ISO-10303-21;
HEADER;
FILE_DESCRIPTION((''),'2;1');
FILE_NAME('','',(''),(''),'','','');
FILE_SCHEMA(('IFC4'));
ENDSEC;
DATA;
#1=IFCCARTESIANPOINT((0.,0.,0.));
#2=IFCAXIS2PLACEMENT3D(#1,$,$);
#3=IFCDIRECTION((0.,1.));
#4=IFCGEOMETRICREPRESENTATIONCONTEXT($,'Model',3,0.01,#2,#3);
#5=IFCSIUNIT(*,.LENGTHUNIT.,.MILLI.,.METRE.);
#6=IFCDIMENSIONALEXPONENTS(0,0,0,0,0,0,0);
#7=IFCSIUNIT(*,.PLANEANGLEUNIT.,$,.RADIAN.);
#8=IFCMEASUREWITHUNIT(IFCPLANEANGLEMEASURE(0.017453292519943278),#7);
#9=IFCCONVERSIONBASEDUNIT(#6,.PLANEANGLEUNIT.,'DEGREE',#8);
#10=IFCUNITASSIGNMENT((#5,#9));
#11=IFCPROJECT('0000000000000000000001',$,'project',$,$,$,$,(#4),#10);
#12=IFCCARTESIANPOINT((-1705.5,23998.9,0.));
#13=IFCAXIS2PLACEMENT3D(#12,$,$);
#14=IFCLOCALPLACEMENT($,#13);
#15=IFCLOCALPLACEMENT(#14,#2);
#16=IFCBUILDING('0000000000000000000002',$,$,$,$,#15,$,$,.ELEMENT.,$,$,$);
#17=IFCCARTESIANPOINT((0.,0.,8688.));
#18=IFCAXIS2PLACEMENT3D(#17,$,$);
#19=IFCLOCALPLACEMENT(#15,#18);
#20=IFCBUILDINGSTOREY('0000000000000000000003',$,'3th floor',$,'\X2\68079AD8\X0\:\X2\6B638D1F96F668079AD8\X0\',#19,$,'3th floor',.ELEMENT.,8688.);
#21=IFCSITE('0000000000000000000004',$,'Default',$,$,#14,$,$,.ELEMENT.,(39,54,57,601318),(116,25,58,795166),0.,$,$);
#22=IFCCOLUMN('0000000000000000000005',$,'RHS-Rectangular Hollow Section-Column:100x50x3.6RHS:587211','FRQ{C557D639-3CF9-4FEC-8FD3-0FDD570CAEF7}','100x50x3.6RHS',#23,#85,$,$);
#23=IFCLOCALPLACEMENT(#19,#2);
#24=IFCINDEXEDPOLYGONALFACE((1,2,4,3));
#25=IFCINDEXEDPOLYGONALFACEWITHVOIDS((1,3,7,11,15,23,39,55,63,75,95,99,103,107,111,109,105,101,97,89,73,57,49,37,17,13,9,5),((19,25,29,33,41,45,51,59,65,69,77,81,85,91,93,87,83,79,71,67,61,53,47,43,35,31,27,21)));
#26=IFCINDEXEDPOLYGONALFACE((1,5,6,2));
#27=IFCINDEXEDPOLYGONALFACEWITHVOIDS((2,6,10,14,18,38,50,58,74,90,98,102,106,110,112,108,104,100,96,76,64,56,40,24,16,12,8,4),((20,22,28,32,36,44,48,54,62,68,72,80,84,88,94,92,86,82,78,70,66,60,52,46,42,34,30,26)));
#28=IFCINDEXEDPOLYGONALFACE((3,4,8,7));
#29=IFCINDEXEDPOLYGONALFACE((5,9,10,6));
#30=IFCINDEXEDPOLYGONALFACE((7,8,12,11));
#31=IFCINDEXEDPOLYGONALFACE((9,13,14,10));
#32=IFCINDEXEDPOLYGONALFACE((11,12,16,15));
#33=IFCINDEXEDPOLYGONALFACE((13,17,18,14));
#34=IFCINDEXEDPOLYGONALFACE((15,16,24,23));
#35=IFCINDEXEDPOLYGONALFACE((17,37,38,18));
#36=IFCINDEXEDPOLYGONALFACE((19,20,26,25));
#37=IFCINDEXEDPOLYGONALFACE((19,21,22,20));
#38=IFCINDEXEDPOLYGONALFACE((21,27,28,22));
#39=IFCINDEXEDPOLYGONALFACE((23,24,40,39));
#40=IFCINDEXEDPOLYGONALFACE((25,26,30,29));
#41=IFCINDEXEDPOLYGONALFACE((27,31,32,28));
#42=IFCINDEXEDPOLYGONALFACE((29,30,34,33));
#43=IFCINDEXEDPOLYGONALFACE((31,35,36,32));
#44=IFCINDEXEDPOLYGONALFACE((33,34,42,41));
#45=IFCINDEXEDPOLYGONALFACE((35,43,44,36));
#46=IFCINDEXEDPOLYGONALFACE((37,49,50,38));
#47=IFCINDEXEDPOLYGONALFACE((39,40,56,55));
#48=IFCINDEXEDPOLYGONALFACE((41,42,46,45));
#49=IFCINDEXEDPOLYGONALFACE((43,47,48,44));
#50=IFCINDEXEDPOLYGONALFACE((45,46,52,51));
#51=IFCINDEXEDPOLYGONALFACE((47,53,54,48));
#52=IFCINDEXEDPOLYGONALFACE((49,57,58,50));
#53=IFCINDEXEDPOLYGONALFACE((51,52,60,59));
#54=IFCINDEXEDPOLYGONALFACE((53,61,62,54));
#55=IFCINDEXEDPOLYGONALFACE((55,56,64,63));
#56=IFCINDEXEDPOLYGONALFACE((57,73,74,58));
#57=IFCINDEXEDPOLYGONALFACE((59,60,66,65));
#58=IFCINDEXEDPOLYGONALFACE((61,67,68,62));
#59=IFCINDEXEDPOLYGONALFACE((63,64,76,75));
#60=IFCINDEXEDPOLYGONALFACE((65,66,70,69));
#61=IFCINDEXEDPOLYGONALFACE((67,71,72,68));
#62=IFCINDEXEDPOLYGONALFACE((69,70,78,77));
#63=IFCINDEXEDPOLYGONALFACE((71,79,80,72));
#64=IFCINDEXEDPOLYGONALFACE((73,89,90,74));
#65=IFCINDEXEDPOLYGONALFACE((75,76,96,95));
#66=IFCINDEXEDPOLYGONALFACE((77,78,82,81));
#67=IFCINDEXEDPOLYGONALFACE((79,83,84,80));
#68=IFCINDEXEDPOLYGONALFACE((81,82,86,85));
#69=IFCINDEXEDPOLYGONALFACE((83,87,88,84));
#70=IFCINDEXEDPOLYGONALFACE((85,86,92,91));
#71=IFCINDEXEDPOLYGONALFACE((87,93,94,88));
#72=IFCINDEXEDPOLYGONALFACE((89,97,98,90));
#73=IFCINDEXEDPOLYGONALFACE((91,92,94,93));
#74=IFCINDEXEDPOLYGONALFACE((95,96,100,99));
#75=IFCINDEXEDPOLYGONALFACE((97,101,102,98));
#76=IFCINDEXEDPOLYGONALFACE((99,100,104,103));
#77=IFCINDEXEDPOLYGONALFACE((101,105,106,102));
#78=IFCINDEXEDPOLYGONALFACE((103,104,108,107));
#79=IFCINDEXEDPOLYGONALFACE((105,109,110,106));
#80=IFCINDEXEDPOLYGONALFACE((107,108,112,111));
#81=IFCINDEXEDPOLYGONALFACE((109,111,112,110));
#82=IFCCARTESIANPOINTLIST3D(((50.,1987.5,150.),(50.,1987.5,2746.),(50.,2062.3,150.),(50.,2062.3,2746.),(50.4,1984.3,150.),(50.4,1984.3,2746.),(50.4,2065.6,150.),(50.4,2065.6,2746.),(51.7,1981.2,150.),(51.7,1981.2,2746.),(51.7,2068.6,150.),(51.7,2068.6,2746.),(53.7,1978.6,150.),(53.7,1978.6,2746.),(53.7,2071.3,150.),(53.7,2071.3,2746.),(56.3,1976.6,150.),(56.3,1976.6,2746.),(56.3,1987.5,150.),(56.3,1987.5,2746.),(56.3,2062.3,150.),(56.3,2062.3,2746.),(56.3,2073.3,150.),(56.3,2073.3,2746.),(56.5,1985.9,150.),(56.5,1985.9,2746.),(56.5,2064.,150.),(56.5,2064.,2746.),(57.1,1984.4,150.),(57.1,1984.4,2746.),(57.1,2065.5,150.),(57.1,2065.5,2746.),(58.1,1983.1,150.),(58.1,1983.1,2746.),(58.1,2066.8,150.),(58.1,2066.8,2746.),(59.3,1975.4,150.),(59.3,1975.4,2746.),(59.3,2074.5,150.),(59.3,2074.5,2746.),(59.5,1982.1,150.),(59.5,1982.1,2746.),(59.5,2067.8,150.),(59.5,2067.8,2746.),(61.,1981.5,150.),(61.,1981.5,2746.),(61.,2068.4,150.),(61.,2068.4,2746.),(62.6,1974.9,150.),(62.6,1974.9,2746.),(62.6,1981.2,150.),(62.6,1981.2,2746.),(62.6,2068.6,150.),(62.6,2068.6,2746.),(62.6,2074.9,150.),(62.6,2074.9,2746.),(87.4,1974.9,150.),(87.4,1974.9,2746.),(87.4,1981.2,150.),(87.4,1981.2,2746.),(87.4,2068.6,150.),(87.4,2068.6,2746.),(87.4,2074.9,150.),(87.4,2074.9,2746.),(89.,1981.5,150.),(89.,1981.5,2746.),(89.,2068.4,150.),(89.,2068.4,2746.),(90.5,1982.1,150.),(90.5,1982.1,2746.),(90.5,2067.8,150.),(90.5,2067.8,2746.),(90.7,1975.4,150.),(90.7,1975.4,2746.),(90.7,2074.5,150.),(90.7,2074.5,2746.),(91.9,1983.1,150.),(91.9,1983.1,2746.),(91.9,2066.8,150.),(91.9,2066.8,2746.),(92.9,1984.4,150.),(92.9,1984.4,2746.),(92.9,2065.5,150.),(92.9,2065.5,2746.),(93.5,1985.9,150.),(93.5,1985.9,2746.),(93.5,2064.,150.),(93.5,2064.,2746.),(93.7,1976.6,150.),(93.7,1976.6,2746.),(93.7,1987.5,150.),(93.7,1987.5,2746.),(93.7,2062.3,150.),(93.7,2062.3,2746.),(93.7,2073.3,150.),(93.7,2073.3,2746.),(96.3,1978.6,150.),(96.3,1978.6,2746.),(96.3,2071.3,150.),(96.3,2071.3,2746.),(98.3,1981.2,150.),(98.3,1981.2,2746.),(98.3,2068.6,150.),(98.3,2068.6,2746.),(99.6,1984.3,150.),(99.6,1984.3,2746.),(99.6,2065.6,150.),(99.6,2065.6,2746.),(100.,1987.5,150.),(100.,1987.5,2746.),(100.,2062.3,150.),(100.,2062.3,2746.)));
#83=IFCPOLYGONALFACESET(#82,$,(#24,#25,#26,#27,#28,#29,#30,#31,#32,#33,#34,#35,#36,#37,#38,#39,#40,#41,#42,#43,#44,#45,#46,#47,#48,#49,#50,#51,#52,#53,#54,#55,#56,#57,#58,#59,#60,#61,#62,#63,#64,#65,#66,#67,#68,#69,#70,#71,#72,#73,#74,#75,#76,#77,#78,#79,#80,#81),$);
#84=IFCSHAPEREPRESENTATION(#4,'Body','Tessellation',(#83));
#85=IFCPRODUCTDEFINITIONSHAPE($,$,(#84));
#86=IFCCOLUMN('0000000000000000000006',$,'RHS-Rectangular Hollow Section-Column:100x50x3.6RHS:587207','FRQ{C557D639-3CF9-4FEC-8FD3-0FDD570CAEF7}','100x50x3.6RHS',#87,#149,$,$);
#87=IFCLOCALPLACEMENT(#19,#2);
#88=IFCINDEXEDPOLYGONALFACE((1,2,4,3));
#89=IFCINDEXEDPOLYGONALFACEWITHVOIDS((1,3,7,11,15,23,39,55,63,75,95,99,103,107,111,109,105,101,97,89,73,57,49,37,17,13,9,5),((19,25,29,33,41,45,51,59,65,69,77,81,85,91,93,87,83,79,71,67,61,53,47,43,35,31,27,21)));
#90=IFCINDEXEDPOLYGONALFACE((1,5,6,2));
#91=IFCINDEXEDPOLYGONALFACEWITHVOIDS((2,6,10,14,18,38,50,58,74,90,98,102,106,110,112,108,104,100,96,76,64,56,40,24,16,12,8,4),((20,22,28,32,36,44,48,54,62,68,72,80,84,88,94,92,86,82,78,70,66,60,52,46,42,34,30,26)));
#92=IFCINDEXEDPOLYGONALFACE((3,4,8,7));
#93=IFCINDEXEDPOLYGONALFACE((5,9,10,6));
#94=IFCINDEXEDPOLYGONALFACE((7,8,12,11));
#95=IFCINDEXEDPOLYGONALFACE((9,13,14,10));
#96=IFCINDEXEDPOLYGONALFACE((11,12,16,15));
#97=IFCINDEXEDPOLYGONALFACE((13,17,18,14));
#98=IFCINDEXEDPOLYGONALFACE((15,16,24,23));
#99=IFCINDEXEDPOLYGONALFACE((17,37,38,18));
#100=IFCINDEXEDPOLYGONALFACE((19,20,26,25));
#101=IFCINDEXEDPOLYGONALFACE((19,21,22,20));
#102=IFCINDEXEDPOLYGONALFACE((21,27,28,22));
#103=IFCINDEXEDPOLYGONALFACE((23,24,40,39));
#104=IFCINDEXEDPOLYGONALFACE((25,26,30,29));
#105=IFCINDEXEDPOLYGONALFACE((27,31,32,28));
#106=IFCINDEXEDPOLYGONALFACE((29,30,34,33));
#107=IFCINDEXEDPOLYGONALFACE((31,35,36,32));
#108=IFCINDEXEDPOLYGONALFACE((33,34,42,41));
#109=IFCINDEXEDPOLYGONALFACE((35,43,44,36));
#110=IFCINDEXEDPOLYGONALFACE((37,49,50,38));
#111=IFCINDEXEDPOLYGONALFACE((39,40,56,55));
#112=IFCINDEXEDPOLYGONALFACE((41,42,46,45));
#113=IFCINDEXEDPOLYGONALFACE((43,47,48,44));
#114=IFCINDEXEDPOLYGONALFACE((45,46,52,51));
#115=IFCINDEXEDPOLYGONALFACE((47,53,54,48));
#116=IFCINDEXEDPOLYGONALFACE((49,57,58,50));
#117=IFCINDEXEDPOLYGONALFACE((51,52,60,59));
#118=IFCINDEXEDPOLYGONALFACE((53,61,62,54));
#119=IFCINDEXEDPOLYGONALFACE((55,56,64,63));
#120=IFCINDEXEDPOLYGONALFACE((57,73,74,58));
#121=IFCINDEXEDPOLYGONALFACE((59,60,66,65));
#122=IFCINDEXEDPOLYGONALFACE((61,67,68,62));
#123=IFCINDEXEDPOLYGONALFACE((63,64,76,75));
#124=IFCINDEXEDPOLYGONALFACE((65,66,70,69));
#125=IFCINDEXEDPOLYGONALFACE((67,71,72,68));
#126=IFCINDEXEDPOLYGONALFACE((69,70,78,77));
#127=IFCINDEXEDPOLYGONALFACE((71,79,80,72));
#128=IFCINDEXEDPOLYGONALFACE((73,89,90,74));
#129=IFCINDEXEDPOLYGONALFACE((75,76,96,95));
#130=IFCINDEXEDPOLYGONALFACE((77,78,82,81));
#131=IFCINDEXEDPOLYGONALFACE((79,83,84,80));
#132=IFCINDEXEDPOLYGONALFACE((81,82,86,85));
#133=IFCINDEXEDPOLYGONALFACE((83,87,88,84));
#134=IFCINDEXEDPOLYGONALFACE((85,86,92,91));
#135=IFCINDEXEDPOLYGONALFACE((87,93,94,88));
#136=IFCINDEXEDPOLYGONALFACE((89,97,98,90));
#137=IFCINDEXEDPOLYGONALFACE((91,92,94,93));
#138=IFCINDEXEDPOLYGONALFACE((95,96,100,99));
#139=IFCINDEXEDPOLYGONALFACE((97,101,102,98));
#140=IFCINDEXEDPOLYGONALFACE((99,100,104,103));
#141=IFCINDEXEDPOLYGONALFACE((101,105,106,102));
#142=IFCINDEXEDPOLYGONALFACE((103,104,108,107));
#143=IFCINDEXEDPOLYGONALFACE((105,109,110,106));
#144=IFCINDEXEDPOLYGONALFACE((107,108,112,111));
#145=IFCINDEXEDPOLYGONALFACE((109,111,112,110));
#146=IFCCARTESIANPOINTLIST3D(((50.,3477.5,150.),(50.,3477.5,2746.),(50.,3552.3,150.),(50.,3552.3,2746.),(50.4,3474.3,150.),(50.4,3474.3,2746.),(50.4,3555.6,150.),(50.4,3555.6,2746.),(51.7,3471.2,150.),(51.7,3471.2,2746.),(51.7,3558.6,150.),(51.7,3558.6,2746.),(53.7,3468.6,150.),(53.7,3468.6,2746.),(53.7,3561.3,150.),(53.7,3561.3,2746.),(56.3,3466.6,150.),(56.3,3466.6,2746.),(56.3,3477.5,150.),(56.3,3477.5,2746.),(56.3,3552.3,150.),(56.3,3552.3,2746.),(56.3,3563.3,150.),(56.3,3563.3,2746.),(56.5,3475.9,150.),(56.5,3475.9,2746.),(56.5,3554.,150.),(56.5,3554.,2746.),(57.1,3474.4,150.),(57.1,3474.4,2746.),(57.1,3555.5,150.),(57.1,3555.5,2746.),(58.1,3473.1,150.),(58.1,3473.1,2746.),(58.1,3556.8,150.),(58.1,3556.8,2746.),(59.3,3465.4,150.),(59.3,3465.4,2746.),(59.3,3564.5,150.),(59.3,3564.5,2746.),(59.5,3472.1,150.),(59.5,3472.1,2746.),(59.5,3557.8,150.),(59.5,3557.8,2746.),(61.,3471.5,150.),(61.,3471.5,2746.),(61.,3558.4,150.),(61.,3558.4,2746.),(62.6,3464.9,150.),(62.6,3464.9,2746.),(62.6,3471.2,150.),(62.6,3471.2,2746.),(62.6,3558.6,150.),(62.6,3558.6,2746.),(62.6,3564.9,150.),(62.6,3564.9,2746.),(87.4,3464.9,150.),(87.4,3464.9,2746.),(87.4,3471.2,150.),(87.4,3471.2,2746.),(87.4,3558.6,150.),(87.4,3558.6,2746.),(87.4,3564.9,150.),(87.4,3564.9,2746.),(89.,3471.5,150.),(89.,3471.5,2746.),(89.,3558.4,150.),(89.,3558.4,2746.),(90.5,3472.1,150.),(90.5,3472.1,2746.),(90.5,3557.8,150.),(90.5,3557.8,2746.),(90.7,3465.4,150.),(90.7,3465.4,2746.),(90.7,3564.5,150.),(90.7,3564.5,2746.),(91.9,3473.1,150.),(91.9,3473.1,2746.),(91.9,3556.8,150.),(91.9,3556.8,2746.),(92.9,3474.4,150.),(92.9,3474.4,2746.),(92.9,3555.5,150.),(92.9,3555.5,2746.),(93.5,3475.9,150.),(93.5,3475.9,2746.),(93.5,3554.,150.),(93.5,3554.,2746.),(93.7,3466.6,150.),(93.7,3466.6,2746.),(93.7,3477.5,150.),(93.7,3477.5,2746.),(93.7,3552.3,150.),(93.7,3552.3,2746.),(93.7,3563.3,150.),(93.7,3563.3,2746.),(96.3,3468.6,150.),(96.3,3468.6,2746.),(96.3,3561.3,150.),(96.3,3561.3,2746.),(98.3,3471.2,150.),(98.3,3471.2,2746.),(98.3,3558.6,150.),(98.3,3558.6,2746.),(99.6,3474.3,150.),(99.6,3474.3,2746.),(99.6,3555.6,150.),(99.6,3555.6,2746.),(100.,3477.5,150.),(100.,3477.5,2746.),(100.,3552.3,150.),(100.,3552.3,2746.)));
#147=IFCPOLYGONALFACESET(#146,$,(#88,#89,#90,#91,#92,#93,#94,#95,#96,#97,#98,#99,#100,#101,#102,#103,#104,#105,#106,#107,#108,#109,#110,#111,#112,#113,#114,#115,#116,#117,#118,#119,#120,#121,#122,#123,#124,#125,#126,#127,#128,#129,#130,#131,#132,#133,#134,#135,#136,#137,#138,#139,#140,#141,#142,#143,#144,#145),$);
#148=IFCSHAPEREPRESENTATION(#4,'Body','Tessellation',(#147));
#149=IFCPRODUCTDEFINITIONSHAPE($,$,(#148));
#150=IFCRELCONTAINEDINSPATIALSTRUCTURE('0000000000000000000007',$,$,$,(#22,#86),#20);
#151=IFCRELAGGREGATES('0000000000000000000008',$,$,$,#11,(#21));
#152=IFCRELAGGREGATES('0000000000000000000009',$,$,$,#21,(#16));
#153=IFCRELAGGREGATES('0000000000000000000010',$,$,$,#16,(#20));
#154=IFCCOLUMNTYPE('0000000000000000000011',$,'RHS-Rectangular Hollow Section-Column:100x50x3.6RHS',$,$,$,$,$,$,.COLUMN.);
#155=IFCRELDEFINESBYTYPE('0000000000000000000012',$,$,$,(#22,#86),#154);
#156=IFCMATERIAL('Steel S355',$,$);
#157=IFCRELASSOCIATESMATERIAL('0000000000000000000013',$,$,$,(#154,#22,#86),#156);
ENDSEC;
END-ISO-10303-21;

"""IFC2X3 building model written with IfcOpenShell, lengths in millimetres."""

from ifc_helpers import new_model, entity, si_unit, converted_unit, direction, frame, origin, origin_2d, place, context, project, spatial, hollow_rectangle, extrude, clip, halfspace, material, type_object, element, save


model = new_model("IFC2X3")

# Units and contexts
model_context = context("Model", 3, precision=0.01, world=origin(), true_north=direction((0.0, 1.0)))
ifc_project = project(units=[si_unit("LENGTHUNIT", "METRE", prefix="MILLI"), converted_unit("PLANEANGLEUNIT", "DEGREE", entity("IfcPlaneAngleMeasure", 0.017453292519943278), si_unit("PLANEANGLEUNIT", "RADIAN"), dimensions=[0, 0, 0, 0, 0, 0, 0])], contexts=[model_context])

# Site, building, storey
site_placement = place(None, frame((-1705.5, 23998.9, 0.0)))
site = spatial("IfcSite", under=ifc_project, at=site_placement, Name="Default", CompositionType="ELEMENT", RefLatitude=(39, 54, 57, 601318), RefLongitude=(116, 25, 58, 795166), RefElevation=0.0)
building_placement = place(site_placement, origin())
building = spatial("IfcBuilding", under=site, at=building_placement, CompositionType="ELEMENT")
storey_placement = place(building_placement, frame((0.0, 0.0, 8688.0)))
storey = spatial("IfcBuildingStorey", under=building, at=storey_placement, Name="3th floor", ObjectType="标高:正负零标高", LongName="3th floor", CompositionType="ELEMENT", Elevation=8688.0)

# Shared definitions
ifc_material_1 = material(Name="Steel S355")

# Columns
column_type_1 = type_object("IfcColumnType", Name="RHS-Rectangular Hollow Section-Column:100x50x3.6RHS", PredefinedType="COLUMN", material=ifc_material_1)
column_1_placement = place(storey_placement, frame((75.0, 2024.9, 2746.0), z_axis=(0.0, 0.0, 1.0), x_axis=(-1.0, 0.0, 0.0)))
element("IfcColumn", 1, at=column_1_placement, inside=storey, type_object=column_type_1, material=ifc_material_1, Name="RHS-Rectangular Hollow Section-Column:100x50x3.6RHS:587211", Description="FRQ{C557D639-3CF9-4FEC-8FD3-0FDD570CAEF7}", ObjectType="100x50x3.6RHS", context=model_context, shape_type="Clipping", body=[
    clip(extrude(hollow_rectangle(XDim=50.0, YDim=100.0, WallThickness=6.3, InnerFilletRadius=6.3, OuterFilletRadius=12.6, at=origin_2d()), origin(), (0.0, 0.0, -1.0), 2651.9), halfspace(frame((75.0, 2024.9, -2596.0), z_axis=(0.0, 0.0, 1.0), x_axis=(-1.0, 0.0, 0.0)), True)),
])
column_2_placement = place(storey_placement, frame((75.0, 3514.9, 2746.0), z_axis=(0.0, 0.0, 1.0), x_axis=(-1.0, 0.0, 0.0)))
element("IfcColumn", 2, at=column_2_placement, inside=storey, type_object=column_type_1, material=ifc_material_1, Name="RHS-Rectangular Hollow Section-Column:100x50x3.6RHS:587207", Description="FRQ{C557D639-3CF9-4FEC-8FD3-0FDD570CAEF7}", ObjectType="100x50x3.6RHS", context=model_context, shape_type="Clipping", body=[
    clip(extrude(hollow_rectangle(XDim=50.0, YDim=100.0, WallThickness=6.3, InnerFilletRadius=6.3, OuterFilletRadius=12.6, at=origin_2d()), origin(), (0.0, 0.0, -1.0), 2651.9), halfspace(frame((75.0, 3514.9, -2596.0), z_axis=(0.0, 0.0, 1.0), x_axis=(-1.0, 0.0, 0.0)), True)),
])

save(model, "model.ifc")
